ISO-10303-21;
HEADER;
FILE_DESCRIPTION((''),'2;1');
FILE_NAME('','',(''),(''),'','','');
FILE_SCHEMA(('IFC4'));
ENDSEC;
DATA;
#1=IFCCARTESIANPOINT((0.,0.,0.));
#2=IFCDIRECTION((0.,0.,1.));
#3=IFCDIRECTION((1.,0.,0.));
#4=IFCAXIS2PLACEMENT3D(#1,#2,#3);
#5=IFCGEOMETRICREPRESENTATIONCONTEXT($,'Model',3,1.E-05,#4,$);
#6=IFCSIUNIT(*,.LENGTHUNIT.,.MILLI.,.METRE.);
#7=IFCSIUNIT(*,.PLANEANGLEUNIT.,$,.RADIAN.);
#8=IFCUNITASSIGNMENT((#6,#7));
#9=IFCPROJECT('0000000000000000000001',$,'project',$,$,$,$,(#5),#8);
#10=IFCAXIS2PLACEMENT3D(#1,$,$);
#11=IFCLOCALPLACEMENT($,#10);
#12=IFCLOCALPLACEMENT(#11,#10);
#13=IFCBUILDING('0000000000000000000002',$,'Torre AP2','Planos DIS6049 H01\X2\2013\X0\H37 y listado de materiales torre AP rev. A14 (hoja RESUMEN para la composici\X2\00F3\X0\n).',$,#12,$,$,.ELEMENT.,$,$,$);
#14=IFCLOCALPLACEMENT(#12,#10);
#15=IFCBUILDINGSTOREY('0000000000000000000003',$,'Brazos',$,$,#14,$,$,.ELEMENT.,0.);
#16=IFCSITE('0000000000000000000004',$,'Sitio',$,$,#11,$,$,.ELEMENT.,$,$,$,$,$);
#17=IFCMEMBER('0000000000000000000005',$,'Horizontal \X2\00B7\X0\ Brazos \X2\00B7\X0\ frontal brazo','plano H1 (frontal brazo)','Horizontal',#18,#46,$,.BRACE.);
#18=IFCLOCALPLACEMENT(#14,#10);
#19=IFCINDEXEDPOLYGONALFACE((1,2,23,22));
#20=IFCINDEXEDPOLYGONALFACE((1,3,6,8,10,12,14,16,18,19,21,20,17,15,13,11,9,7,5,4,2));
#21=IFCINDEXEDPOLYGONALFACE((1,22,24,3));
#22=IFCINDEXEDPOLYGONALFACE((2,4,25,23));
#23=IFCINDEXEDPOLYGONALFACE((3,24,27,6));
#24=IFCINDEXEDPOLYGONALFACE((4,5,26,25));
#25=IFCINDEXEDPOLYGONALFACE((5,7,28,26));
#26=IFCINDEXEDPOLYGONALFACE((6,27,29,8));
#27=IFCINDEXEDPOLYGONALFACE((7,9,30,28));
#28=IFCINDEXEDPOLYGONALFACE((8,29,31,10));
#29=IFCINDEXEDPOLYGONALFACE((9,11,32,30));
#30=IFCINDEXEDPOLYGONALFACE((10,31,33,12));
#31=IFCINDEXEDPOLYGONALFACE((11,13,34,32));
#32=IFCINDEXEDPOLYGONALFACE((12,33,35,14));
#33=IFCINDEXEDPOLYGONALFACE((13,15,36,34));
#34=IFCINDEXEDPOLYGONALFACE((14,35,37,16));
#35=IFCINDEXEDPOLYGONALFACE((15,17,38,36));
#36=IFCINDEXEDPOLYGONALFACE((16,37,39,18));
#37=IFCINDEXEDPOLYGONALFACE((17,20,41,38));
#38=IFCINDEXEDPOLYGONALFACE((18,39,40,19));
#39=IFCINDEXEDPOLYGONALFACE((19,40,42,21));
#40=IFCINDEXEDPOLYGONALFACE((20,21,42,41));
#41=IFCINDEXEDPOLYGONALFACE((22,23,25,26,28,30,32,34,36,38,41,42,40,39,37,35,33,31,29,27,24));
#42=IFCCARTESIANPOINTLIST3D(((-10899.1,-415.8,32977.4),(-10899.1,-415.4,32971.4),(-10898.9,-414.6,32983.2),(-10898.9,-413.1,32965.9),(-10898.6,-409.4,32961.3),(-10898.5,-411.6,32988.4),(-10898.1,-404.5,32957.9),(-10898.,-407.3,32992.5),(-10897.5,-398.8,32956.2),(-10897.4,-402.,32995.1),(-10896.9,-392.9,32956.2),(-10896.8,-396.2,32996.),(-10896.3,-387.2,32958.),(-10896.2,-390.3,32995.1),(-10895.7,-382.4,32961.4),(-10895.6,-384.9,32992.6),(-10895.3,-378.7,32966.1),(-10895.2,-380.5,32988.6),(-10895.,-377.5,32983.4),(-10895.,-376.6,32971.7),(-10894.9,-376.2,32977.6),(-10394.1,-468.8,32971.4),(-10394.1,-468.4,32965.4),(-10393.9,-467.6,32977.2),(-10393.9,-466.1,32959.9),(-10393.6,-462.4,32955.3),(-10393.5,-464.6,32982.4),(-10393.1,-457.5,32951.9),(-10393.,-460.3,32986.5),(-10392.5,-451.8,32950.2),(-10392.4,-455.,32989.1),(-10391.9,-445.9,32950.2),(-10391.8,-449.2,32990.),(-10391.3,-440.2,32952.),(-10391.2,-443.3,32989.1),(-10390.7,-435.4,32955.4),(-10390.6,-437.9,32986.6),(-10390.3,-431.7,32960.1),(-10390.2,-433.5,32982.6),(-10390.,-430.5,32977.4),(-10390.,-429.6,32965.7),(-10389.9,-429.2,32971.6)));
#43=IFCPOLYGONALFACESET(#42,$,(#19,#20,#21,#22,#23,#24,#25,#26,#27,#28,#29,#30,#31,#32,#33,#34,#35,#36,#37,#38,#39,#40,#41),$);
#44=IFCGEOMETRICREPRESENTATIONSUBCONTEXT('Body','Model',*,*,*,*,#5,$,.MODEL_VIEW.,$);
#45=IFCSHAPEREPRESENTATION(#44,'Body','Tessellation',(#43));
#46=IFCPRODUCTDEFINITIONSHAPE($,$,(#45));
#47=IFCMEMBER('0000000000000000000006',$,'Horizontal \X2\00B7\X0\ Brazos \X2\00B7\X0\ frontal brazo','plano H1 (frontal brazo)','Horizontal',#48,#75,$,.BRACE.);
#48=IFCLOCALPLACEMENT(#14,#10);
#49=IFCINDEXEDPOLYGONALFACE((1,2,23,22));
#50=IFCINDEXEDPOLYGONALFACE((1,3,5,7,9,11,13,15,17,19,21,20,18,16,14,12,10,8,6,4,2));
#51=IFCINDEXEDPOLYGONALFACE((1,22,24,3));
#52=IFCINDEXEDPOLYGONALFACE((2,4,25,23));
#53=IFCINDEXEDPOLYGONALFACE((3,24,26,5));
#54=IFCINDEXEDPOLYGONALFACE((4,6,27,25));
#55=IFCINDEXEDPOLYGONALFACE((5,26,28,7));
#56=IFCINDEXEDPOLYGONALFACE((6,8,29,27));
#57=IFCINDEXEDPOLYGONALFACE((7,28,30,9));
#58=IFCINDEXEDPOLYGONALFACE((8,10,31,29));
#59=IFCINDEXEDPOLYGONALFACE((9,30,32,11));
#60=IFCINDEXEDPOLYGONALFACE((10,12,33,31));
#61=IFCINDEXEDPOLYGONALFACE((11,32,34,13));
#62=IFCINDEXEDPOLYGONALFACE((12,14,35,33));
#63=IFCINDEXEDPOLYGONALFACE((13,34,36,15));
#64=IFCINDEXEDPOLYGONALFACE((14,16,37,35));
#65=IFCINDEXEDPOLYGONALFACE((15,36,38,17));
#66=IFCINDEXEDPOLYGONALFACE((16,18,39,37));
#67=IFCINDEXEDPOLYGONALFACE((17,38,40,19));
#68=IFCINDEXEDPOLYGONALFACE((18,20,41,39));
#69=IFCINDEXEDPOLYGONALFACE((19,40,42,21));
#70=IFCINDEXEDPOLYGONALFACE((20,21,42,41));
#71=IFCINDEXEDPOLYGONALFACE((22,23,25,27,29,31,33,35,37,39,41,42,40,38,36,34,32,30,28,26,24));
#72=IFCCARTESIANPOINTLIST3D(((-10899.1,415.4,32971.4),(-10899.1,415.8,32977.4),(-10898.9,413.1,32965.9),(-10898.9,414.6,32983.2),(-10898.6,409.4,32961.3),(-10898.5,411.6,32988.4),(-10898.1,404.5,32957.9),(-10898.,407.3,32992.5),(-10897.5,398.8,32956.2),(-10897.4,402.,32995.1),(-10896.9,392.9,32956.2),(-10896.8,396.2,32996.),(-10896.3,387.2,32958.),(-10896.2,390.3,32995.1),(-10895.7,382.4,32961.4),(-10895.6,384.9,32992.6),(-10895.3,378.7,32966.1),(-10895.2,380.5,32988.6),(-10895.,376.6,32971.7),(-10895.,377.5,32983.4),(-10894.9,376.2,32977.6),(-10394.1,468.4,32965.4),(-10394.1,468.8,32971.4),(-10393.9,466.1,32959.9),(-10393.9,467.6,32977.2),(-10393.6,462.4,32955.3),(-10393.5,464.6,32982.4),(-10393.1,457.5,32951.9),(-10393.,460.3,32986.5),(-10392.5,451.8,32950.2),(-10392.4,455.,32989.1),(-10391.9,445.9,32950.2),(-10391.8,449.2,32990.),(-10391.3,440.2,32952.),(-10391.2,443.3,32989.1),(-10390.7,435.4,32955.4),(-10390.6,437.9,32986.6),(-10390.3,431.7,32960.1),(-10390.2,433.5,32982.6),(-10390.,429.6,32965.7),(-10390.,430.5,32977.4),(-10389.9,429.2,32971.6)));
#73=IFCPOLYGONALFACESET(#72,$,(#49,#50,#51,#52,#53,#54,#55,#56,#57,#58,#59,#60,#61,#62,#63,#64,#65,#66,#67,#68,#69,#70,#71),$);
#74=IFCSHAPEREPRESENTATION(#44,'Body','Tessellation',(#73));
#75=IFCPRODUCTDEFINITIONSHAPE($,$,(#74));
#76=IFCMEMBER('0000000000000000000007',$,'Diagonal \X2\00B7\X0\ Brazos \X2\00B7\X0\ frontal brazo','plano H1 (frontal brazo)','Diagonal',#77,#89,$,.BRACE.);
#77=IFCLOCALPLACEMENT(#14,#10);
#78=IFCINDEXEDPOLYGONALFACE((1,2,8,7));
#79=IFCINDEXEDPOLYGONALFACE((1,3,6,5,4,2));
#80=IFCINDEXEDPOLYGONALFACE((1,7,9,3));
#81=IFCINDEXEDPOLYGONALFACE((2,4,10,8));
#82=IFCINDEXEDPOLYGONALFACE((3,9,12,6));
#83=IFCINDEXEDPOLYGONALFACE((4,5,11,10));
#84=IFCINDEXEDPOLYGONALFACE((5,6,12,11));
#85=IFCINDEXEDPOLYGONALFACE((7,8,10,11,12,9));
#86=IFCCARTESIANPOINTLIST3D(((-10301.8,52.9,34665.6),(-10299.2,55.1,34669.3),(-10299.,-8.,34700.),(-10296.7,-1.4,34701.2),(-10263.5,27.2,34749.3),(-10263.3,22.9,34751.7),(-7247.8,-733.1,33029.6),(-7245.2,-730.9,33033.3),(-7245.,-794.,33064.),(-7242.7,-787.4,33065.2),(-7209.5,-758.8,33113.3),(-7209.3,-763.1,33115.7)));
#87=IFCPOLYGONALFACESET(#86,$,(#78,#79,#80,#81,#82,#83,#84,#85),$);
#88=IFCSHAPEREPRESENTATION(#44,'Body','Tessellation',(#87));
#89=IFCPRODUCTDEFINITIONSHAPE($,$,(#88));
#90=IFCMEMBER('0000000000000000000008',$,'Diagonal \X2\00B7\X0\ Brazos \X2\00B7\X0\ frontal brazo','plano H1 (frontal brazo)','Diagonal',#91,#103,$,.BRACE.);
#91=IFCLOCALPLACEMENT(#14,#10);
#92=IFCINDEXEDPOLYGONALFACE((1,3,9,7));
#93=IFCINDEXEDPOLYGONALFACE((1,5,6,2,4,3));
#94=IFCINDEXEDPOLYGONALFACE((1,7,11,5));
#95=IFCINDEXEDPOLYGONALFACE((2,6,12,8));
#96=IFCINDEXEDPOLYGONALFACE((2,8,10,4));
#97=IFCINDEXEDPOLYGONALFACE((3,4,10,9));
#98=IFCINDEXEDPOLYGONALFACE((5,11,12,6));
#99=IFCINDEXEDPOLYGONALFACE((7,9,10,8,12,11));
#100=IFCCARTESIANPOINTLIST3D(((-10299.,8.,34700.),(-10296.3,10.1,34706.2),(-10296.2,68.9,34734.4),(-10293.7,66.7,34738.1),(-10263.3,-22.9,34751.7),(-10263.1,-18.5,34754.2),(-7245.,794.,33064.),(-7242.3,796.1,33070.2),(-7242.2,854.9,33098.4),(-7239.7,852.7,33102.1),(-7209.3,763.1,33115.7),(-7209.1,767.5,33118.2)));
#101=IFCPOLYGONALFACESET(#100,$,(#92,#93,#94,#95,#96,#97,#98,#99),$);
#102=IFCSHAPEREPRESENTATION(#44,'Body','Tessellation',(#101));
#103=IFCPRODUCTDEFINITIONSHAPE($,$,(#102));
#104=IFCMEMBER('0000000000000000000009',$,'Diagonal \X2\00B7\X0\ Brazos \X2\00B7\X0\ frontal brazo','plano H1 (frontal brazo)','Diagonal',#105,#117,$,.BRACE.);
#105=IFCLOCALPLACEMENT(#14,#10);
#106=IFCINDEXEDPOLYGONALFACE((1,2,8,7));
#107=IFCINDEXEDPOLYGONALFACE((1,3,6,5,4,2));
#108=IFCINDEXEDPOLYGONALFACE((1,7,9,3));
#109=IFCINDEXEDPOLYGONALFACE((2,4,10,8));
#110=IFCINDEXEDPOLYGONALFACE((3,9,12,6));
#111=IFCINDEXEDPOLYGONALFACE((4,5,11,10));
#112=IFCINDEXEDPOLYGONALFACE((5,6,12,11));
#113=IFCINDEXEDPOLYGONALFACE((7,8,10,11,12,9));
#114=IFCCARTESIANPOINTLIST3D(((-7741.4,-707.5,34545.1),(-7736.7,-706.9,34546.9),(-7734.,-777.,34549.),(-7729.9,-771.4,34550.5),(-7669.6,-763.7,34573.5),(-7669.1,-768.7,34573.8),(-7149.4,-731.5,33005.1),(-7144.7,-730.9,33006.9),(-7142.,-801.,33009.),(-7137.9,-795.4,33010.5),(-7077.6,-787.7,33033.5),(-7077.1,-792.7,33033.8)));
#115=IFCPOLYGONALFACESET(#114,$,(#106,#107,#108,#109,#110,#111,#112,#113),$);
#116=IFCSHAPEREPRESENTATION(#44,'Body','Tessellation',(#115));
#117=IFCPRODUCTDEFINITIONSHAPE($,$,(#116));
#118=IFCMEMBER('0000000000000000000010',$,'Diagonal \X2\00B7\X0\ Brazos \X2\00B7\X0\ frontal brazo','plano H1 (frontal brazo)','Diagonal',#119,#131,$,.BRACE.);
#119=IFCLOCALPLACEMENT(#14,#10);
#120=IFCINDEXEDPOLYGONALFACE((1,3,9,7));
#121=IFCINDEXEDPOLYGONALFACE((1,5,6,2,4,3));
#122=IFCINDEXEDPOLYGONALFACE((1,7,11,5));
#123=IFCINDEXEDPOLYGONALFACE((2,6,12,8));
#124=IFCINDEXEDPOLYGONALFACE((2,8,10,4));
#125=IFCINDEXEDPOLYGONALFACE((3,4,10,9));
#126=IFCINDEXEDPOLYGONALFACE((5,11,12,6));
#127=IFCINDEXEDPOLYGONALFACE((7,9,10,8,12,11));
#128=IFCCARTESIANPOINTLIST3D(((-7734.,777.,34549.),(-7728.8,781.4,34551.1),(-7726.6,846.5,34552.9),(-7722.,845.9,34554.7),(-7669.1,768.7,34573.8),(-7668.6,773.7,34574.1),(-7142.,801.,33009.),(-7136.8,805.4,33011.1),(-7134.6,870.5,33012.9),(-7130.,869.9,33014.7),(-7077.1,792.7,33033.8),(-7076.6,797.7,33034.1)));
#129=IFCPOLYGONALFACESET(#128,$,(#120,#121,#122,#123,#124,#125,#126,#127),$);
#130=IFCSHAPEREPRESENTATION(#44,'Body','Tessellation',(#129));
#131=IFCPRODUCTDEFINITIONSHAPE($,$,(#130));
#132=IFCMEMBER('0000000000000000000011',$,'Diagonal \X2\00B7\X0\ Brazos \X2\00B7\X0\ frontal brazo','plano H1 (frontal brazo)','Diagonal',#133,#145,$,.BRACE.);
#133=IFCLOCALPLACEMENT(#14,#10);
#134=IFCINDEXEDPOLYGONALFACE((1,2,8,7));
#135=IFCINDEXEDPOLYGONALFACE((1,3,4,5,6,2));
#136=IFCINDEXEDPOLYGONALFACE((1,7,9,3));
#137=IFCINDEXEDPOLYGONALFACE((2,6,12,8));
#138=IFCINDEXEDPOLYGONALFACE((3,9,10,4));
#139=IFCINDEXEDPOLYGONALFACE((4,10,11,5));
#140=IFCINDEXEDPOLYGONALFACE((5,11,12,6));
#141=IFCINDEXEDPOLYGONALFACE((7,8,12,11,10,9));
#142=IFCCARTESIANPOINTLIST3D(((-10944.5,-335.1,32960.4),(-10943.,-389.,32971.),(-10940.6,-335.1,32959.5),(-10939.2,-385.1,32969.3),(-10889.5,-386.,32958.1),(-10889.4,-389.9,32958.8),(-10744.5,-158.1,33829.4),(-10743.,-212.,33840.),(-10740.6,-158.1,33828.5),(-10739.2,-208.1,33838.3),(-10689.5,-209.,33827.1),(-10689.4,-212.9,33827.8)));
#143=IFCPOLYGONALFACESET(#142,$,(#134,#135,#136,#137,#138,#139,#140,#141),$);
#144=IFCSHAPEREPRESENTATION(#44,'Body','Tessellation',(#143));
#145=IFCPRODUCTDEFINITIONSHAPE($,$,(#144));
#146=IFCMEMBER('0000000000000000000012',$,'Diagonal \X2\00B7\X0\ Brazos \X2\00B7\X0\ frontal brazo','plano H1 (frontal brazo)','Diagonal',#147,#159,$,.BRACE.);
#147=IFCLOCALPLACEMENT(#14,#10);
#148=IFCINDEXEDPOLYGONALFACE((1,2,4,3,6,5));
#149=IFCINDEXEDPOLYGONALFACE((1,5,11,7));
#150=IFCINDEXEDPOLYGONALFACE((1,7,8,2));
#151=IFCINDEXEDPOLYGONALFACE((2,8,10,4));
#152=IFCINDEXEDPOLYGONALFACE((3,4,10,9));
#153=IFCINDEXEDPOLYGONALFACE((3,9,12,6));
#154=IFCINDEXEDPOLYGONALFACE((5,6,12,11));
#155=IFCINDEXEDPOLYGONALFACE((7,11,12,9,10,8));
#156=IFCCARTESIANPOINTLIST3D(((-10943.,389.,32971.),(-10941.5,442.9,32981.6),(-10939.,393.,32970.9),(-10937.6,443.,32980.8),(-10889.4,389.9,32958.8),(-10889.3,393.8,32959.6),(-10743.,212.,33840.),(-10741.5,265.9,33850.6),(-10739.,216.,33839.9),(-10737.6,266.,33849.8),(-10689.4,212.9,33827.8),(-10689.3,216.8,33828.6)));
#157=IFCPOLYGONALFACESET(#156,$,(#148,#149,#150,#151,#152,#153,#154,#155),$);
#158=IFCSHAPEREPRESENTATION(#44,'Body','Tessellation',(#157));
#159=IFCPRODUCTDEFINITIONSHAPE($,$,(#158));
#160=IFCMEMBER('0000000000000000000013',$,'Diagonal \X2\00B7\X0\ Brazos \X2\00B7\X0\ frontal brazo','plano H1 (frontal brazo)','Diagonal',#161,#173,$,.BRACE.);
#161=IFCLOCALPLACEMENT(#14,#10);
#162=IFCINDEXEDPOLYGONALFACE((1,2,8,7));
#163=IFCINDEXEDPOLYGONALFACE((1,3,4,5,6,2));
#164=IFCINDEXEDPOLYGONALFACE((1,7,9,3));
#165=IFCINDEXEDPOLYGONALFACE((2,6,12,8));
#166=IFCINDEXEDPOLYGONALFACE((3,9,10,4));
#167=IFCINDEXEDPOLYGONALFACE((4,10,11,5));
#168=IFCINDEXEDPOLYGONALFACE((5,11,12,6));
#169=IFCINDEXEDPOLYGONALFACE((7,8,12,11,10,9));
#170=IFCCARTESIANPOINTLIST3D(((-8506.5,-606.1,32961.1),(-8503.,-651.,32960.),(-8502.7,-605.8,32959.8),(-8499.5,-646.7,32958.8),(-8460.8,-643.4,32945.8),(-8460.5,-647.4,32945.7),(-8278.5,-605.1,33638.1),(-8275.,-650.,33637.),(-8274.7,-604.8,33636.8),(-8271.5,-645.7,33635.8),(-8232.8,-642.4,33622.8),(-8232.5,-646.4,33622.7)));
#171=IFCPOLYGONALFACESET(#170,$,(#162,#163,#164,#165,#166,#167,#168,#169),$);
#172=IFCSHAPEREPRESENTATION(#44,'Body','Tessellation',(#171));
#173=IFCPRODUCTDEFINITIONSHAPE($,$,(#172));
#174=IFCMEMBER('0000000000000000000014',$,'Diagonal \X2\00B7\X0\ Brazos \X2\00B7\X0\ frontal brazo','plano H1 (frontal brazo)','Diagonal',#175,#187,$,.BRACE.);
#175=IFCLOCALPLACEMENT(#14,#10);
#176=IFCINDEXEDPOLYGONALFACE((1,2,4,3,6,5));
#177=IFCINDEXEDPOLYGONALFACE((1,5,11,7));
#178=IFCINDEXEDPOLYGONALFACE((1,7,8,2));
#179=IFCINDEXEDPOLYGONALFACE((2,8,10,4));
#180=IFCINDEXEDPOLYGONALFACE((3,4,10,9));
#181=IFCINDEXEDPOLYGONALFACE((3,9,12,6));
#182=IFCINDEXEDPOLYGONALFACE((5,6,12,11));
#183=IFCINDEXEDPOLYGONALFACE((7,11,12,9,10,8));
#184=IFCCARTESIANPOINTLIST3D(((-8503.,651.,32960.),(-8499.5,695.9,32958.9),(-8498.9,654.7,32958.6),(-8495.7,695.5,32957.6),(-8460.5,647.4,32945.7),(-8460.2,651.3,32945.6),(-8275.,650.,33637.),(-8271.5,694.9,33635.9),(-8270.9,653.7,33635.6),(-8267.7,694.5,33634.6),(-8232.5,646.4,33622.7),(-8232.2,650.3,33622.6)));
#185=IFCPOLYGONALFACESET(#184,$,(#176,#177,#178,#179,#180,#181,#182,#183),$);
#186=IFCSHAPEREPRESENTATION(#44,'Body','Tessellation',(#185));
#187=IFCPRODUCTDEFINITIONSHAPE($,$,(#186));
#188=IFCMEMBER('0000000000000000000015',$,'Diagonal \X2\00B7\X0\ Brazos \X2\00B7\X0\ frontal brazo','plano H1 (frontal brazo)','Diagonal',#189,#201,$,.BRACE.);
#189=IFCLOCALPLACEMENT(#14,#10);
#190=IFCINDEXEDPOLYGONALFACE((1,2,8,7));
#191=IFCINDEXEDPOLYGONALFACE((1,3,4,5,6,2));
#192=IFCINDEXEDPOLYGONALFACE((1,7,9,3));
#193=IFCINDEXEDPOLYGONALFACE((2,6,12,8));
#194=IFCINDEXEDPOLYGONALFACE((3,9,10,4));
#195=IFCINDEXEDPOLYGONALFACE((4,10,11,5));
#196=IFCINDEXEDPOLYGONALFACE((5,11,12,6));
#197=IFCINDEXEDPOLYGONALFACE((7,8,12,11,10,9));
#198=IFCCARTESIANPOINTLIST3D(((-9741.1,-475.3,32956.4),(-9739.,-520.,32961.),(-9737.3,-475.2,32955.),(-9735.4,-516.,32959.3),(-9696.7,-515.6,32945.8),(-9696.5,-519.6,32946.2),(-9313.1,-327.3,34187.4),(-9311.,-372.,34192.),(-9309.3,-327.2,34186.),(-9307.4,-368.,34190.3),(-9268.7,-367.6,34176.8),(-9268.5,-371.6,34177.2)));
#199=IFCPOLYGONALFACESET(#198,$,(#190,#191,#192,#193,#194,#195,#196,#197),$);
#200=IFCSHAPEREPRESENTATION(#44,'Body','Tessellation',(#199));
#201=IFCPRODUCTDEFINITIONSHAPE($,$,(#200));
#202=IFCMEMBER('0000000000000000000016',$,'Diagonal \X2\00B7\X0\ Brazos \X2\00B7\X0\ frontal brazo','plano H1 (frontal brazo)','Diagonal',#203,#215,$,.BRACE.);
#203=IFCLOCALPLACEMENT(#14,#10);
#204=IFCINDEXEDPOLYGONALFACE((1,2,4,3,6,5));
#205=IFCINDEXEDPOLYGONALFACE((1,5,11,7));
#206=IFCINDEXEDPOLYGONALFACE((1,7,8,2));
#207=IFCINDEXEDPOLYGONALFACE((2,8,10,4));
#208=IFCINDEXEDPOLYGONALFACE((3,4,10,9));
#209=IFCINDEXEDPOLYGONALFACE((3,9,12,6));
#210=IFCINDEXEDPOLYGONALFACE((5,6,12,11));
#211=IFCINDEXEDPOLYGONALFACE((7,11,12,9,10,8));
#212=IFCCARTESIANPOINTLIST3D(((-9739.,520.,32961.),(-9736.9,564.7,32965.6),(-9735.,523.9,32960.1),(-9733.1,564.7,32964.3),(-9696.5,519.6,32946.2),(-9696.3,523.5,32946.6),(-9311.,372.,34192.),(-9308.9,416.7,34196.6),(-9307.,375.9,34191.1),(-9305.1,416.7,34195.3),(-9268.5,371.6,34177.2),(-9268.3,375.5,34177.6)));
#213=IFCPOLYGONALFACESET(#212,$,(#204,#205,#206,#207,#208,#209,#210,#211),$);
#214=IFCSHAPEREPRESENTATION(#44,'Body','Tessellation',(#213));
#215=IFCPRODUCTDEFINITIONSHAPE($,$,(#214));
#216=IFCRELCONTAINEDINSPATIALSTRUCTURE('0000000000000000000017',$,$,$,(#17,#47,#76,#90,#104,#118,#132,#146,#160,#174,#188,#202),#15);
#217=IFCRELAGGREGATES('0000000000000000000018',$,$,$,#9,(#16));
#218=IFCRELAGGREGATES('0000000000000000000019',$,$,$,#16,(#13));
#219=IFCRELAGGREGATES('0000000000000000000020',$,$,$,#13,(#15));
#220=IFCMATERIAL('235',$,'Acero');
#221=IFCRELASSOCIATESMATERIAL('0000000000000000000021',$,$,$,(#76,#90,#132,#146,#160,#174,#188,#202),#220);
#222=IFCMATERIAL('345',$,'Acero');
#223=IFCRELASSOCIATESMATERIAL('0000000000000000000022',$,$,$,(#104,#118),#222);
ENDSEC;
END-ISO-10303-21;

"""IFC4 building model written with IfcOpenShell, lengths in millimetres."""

from ifc_helpers import new_model, si_unit, frame, frame_2d, origin, origin_with_axes, place, context, subcontext, project, spatial, circle, l_section, extrude, material, element, save


model = new_model("IFC4")

# Units and contexts
model_context = context("Model", 3, precision=1e-05, world=origin_with_axes())
body_context = subcontext(model_context, "Body", "Model", "MODEL_VIEW")
ifc_project = project(units=[si_unit("LENGTHUNIT", "METRE", prefix="MILLI"), si_unit("PLANEANGLEUNIT", "RADIAN")], contexts=[model_context])

# Site, building, storey
site_placement = place(None, origin())
site = spatial("IfcSite", under=ifc_project, at=site_placement, Name="Sitio", CompositionType="ELEMENT")
building_placement = place(site_placement, origin())
building = spatial("IfcBuilding", under=site, at=building_placement, Name="Torre AP2", Description="Planos DIS6049 H01–H37 y listado de materiales torre AP rev. A14 (hoja RESUMEN para la composición).", CompositionType="ELEMENT")
storey_placement = place(building_placement, origin())
storey = spatial("IfcBuildingStorey", under=building, at=storey_placement, Name="Brazos", CompositionType="ELEMENT", Elevation=0.0)

# Members
for number, where, z_axis, x_axis, name in (
    (1, (-10392.0, -449.0, 32970.0), (-0.994468, 0.10437, 0.011815), (0.104986, 0.991163, 0.081074), "Horizontal · Brazos · frontal brazo"),
    (2, (-10392.0, 449.0, 32970.0), (-0.994468, -0.10437, 0.011815), (0.104986, -0.991163, 0.081074), "Horizontal · Brazos · frontal brazo"),
):
    element("IfcMember", number, at=place(storey_placement, frame(where, z_axis=z_axis, x_axis=x_axis)), inside=storey, Name=name, Description="plano H1 (frontal brazo)", ObjectType="Horizontal", PredefinedType="BRACE", context=body_context, shape_type="SweptSolid", body=[
        extrude(circle(Radius=20.0), None, (0.0, 0.0, 1.0), 507.8),
    ])
ifc_material_1 = material(Name="235", Category="Acero")
for number, where, z_axis, x_axis, name in (
    (3, (-7245.0, -794.0, 33064.0), (-0.859644, 0.221244, 0.460503), (0.509345, 0.441284, 0.738808), "Diagonal · Brazos · frontal brazo"),
    (4, (-7245.0, 794.0, 33064.0), (-0.859644, -0.221244, 0.460503), (0.509345, -0.441284, 0.738808), "Diagonal · Brazos · frontal brazo"),
):
    element("IfcMember", number, at=place(storey_placement, frame(where, z_axis=z_axis, x_axis=x_axis)), inside=storey, material=ifc_material_1, Name=name, Description="plano H1 (frontal brazo)", ObjectType="Diagonal", PredefinedType="BRACE", context=body_context, shape_type="SweptSolid", body=[
        extrude(l_section(Depth=70.0, Width=70.0, Thickness=5.0, at=frame_2d((35.0, 35.0))), None, (0.0, 0.0, 1.0), 3552.6),
    ])
ifc_material_2 = material(Name="345", Category="Acero")
for number, where, z_axis, x_axis, name in (
    (5, (-7142.0, -801.0, 33009.0), (-0.358779, 0.014545, 0.933309), (0.927462, 0.118373, 0.354686), "Diagonal · Brazos · frontal brazo"),
    (6, (-7142.0, 801.0, 33009.0), (-0.358779, -0.014545, 0.933309), (0.927462, -0.118373, 0.354686), "Diagonal · Brazos · frontal brazo"),
):
    element("IfcMember", number, at=place(storey_placement, frame(where, z_axis=z_axis, x_axis=x_axis)), inside=storey, material=ifc_material_2, Name=name, Description="plano H1 (frontal brazo)", ObjectType="Diagonal", PredefinedType="BRACE", context=body_context, shape_type="SweptSolid", body=[
        extrude(l_section(Depth=70.0, Width=70.0, Thickness=5.0, at=frame_2d((35.0, 35.0))), None, (0.0, 0.0, 1.0), 1650.0),
    ])
for number, where, z_axis, x_axis, name in (
    (7, (-10943.0, -389.0, 32971.0), (0.219994, 0.194695, 0.955875), (0.975122, -0.016589, -0.221045), "Diagonal · Brazos · frontal brazo"),
    (8, (-10943.0, 389.0, 32971.0), (0.219994, -0.194695, 0.955875), (0.975122, 0.016589, -0.221045), "Diagonal · Brazos · frontal brazo"),
):
    element("IfcMember", number, at=place(storey_placement, frame(where, z_axis=z_axis, x_axis=x_axis)), inside=storey, material=ifc_material_1, Name=name, Description="plano H1 (frontal brazo)", ObjectType="Diagonal", PredefinedType="BRACE", context=body_context, shape_type="SweptSolid", body=[
        extrude(l_section(Depth=55.0, Width=55.0, Thickness=4.0, at=frame_2d((27.5, 27.5))), None, (0.0, 0.0, 1.0), 909.1),
    ])
for number, where, z_axis, x_axis, name in (
    (9, (-8503.0, -651.0, 32960.0), (0.319166, 0.0014, 0.947698), (0.944542, 0.081082, -0.318223), "Diagonal · Brazos · frontal brazo"),
    (10, (-8503.0, 651.0, 32960.0), (0.319166, -0.0014, 0.947698), (0.944542, -0.081082, -0.318223), "Diagonal · Brazos · frontal brazo"),
):
    element("IfcMember", number, at=place(storey_placement, frame(where, z_axis=z_axis, x_axis=x_axis)), inside=storey, material=ifc_material_1, Name=name, Description="plano H1 (frontal brazo)", ObjectType="Diagonal", PredefinedType="BRACE", context=body_context, shape_type="SweptSolid", body=[
        extrude(l_section(Depth=45.0, Width=45.0, Thickness=4.0, at=frame_2d((22.5, 22.5))), None, (0.0, 0.0, 1.0), 714.4),
    ])
for number, where, z_axis, x_axis, name in (
    (11, (-9739.0, -520.0, 32961.0), (0.326304, 0.112834, 0.938506), (0.944119, 0.009962, -0.329454), "Diagonal · Brazos · frontal brazo"),
    (12, (-9739.0, 520.0, 32961.0), (0.326304, -0.112834, 0.938506), (0.944119, -0.009962, -0.329454), "Diagonal · Brazos · frontal brazo"),
):
    element("IfcMember", number, at=place(storey_placement, frame(where, z_axis=z_axis, x_axis=x_axis)), inside=storey, material=ifc_material_1, Name=name, Description="plano H1 (frontal brazo)", ObjectType="Diagonal", PredefinedType="BRACE", context=body_context, shape_type="SweptSolid", body=[
        extrude(l_section(Depth=45.0, Width=45.0, Thickness=4.0, at=frame_2d((22.5, 22.5))), None, (0.0, 0.0, 1.0), 1311.7),
    ])

save(model, "model.ifc")
